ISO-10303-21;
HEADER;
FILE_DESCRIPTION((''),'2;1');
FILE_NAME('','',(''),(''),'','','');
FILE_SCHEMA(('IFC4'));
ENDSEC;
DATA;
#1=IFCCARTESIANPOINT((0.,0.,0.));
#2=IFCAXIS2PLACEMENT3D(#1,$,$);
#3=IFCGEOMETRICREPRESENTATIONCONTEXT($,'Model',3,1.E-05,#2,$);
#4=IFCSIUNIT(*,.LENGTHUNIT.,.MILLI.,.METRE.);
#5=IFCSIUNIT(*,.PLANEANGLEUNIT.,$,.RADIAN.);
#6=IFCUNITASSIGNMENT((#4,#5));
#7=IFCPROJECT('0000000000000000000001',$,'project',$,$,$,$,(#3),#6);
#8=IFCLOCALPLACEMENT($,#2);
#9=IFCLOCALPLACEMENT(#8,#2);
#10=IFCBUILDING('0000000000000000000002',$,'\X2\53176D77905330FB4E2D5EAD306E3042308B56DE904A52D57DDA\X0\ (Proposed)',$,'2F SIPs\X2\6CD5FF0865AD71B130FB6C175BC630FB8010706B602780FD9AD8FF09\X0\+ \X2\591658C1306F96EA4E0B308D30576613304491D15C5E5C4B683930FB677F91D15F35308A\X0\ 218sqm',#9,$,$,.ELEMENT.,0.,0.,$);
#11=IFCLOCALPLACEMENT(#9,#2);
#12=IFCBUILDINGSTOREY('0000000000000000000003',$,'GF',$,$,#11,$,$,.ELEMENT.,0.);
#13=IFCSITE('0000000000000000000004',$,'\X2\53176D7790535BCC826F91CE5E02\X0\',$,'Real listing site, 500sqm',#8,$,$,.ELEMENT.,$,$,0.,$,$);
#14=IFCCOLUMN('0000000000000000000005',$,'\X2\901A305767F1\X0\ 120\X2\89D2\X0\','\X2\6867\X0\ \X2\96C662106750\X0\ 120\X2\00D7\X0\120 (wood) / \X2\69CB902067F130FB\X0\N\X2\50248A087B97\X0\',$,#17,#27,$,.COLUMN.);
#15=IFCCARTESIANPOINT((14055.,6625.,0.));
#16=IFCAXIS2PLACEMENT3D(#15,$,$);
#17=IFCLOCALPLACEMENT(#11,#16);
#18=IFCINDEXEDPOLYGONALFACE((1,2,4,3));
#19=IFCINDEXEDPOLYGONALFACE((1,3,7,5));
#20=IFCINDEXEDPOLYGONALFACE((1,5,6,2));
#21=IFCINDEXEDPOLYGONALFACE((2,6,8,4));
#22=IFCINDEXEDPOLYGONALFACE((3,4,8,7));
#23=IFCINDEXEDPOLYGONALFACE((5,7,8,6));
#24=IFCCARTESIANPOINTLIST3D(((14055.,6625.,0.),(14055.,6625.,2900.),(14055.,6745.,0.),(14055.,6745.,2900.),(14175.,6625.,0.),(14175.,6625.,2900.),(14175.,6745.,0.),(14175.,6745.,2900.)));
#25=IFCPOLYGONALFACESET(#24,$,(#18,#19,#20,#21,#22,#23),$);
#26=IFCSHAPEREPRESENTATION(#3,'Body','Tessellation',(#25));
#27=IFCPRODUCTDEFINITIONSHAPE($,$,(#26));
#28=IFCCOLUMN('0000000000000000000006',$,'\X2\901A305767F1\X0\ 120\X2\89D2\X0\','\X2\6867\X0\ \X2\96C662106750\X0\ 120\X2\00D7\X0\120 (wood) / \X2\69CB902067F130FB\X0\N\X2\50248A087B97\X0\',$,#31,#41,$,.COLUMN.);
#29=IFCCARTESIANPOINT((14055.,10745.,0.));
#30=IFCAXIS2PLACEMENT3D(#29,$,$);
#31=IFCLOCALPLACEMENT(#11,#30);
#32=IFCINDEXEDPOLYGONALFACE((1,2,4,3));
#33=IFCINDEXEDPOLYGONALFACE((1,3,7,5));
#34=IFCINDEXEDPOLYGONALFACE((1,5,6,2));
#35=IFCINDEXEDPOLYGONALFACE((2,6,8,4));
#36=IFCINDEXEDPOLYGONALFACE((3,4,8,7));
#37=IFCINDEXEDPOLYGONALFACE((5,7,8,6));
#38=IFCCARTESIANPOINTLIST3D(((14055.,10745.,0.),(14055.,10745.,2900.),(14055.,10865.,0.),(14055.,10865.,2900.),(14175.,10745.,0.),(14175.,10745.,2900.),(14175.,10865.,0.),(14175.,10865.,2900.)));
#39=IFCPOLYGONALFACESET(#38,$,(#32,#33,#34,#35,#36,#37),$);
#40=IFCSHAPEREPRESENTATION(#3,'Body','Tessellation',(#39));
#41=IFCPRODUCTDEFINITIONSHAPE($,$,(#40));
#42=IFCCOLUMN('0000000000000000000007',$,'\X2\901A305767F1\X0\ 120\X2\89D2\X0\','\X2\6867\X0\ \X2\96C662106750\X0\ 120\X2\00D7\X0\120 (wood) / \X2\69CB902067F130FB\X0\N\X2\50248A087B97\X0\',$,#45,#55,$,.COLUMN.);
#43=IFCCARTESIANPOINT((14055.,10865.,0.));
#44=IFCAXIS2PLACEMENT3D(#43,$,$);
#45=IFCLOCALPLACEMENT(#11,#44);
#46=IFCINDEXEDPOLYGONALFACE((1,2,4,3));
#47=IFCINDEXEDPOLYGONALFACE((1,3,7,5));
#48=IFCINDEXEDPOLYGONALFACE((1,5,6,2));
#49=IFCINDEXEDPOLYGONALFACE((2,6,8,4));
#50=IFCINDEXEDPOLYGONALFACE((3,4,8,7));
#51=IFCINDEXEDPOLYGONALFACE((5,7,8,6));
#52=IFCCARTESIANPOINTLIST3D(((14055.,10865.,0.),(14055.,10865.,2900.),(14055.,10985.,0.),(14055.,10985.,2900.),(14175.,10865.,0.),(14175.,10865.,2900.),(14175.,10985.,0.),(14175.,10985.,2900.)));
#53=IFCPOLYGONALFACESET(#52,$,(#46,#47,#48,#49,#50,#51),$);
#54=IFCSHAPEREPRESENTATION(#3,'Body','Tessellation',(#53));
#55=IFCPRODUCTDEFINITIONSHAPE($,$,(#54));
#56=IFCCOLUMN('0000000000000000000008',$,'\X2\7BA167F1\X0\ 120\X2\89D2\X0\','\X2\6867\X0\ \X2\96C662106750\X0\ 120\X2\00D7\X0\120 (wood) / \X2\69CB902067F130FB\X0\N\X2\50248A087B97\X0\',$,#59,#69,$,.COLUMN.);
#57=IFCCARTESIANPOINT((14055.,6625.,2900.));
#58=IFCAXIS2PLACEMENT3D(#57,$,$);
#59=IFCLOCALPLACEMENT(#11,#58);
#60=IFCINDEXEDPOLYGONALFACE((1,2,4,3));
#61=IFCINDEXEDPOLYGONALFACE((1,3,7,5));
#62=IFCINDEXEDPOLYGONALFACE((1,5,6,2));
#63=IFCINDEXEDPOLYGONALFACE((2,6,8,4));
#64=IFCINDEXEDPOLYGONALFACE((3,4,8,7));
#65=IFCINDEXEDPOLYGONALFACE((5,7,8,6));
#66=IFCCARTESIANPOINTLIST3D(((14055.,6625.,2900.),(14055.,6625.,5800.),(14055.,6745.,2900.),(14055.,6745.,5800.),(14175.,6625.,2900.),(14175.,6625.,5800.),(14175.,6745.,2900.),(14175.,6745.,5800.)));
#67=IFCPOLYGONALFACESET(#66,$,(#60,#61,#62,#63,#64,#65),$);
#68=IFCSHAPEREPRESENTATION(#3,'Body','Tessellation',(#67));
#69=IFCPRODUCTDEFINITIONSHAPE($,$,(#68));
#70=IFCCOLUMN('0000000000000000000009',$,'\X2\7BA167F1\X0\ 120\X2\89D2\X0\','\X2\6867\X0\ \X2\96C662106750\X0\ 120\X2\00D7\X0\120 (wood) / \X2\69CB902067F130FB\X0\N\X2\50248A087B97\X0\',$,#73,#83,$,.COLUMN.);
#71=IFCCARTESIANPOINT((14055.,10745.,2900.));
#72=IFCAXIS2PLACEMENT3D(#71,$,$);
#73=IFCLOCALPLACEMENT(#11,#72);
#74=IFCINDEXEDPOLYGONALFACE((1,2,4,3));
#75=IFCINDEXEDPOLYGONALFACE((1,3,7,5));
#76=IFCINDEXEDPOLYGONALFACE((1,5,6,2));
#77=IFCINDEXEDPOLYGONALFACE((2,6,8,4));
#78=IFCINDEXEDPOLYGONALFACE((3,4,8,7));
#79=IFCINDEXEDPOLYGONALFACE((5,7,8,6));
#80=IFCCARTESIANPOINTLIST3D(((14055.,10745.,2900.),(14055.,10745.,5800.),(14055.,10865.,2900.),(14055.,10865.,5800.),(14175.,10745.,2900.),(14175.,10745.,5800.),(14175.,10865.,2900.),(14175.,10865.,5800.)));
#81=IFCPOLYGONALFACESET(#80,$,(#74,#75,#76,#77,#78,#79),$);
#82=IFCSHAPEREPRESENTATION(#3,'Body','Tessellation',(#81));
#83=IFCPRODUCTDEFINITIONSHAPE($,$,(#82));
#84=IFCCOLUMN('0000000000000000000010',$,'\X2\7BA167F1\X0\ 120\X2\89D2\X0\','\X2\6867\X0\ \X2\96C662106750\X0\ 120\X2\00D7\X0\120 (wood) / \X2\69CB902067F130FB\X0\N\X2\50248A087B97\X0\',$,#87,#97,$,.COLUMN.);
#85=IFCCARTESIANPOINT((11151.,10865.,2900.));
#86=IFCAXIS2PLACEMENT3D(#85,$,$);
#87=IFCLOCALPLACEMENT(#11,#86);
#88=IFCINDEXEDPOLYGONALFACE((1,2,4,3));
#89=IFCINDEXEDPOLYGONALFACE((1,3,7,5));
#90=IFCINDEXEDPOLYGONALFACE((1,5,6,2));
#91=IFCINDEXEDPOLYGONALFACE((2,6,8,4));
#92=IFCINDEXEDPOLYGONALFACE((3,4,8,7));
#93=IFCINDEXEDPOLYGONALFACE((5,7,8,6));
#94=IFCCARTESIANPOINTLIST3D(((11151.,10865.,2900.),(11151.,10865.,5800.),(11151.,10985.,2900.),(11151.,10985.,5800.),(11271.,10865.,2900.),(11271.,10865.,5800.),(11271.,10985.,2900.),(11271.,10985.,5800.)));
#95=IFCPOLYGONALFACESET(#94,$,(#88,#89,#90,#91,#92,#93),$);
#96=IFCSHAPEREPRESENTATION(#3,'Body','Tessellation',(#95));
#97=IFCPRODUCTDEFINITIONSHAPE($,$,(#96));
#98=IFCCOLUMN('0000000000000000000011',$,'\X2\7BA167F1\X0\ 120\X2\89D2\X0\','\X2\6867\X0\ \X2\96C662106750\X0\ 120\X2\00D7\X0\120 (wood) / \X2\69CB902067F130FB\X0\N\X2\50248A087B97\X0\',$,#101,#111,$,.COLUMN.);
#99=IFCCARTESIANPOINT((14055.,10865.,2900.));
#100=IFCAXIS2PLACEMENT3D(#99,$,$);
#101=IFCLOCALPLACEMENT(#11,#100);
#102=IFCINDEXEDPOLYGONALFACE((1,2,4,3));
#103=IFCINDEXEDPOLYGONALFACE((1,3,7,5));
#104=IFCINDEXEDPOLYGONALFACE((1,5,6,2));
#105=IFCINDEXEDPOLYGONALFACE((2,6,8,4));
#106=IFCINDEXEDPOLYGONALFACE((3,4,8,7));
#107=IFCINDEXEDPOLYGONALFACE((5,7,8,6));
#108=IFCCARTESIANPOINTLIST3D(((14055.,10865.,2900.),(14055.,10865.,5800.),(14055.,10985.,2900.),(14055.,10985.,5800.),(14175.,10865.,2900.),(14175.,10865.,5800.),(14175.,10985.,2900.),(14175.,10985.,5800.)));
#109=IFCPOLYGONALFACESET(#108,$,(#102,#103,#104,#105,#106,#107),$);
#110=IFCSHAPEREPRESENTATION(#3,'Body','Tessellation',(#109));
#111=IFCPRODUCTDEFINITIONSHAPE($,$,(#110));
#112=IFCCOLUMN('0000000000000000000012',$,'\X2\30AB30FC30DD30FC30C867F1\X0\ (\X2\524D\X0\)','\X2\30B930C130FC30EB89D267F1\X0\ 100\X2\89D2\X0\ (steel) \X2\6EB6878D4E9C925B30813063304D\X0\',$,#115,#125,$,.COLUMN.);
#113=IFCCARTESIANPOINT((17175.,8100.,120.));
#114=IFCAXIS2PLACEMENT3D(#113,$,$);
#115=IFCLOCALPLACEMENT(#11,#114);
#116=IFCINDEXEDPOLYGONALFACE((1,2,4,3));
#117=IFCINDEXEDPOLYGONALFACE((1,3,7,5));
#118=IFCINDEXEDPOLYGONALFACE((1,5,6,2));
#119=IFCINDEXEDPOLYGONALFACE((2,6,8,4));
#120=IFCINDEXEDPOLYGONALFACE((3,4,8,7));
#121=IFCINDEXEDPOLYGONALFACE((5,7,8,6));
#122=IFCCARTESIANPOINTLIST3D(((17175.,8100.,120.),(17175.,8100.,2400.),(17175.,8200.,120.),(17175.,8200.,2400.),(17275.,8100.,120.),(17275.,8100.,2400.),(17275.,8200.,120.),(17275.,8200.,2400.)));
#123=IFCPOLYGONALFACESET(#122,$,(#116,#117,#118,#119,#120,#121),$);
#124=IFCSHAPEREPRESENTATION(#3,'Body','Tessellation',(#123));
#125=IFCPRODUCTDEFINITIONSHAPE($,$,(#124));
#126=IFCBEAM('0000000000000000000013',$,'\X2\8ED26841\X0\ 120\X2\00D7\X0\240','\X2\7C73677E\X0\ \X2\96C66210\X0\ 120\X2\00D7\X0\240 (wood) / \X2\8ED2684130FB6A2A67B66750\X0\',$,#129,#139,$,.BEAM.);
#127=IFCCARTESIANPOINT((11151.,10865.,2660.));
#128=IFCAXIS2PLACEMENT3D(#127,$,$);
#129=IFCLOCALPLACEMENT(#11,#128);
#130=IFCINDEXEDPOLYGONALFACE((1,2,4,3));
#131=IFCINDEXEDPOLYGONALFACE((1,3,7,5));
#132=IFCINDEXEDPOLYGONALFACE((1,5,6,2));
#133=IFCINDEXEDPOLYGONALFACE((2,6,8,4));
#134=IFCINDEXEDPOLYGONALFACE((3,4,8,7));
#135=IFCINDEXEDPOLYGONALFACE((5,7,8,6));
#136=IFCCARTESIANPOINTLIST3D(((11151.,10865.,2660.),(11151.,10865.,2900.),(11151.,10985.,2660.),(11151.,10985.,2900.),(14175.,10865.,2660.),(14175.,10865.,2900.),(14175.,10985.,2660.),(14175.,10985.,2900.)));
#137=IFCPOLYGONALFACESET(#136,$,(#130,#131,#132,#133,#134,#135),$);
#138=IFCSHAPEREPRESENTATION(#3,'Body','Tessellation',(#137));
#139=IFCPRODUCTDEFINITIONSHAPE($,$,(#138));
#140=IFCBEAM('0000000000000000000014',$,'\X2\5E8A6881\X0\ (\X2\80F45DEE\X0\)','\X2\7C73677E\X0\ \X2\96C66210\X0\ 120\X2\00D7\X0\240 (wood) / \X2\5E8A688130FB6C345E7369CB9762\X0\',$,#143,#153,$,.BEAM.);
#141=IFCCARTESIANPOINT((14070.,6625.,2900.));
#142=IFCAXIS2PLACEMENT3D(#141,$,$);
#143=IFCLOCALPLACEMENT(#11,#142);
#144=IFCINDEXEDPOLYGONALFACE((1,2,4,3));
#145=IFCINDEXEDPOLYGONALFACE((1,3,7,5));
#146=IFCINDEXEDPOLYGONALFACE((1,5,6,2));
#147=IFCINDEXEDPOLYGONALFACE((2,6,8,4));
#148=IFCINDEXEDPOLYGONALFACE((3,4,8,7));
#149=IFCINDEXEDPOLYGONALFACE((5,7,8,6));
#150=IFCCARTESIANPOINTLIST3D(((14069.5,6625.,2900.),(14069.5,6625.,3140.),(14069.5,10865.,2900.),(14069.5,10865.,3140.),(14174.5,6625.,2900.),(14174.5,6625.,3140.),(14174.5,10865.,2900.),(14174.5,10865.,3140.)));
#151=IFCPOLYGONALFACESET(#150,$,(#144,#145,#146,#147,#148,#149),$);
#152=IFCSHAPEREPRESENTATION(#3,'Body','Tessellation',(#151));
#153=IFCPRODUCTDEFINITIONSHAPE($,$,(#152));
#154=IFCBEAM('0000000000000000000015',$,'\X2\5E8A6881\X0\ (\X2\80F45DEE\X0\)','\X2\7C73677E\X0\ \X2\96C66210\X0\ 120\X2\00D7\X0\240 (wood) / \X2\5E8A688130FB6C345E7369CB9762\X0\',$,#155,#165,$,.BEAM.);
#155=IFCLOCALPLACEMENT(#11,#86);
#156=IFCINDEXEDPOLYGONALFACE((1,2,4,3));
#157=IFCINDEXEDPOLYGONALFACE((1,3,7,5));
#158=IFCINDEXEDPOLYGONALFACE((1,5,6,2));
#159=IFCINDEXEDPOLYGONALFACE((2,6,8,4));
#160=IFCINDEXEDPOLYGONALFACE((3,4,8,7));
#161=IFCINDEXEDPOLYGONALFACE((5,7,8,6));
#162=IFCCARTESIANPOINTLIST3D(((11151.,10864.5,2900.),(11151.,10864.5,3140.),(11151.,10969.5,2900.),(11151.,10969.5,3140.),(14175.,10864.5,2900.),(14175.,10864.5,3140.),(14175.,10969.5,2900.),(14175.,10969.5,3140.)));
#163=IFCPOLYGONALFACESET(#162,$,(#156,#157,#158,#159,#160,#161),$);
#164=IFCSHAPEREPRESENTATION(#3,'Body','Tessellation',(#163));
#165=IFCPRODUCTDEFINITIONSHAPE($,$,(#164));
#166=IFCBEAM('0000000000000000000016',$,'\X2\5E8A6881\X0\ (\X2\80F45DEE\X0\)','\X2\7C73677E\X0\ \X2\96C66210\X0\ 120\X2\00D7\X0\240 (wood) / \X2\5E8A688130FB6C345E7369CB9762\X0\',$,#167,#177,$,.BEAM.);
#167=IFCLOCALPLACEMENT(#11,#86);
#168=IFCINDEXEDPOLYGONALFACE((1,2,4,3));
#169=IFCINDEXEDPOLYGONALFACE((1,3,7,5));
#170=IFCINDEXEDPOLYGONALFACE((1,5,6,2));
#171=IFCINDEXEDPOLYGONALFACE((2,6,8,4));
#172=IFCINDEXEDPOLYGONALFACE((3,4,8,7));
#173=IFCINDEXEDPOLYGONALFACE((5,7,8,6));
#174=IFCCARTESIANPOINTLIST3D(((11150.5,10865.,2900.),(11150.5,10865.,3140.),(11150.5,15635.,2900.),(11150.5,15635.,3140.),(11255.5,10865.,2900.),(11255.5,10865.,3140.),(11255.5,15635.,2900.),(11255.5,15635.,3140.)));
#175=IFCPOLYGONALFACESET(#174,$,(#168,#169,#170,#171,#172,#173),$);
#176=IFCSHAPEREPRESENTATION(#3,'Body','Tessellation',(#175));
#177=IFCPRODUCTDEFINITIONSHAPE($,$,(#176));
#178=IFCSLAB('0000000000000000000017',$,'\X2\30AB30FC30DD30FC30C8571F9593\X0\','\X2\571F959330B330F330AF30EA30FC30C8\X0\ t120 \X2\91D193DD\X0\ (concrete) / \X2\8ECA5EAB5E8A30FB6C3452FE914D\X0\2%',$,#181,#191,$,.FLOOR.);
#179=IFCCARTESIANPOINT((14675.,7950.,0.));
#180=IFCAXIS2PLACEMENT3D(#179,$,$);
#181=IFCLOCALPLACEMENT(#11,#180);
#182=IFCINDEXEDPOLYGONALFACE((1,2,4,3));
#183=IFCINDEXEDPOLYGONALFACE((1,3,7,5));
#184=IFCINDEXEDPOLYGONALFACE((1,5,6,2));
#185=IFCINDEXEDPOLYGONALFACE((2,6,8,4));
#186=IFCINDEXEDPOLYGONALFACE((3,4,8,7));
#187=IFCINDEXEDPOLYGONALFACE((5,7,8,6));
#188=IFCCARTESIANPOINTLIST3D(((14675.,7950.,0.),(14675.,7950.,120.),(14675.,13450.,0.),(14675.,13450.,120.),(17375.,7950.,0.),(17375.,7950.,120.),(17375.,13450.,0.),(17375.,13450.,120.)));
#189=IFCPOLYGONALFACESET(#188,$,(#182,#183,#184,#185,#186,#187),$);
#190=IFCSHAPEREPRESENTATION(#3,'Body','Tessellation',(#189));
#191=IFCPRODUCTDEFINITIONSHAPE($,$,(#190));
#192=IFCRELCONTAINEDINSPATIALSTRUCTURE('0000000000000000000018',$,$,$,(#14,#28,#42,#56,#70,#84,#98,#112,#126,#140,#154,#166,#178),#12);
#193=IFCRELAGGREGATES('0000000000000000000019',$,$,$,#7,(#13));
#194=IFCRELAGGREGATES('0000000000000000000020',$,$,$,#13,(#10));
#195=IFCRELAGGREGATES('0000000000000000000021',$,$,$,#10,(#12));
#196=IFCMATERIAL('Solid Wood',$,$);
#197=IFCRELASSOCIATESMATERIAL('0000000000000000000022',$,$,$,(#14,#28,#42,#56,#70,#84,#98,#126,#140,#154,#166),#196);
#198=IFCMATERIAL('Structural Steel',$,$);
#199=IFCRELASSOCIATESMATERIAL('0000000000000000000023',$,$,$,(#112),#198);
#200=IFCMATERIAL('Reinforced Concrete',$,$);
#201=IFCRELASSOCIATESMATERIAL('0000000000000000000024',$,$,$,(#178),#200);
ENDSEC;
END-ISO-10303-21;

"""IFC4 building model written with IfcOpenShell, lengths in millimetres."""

from ifc_helpers import new_model, si_unit, frame, frame_2d, origin, place, context, project, spatial, rectangle, extrude, material, element, save


model = new_model("IFC4")

# Units and contexts
model_context = context("Model", 3, precision=1e-05, world=origin())
ifc_project = project(units=[si_unit("LENGTHUNIT", "METRE", prefix="MILLI"), si_unit("PLANEANGLEUNIT", "RADIAN")], contexts=[model_context])

# Site, building, storey
site_placement = place(None, origin())
site = spatial("IfcSite", under=ifc_project, at=site_placement, Name="北海道富良野市", ObjectType="Real listing site, 500sqm", CompositionType="ELEMENT", RefElevation=0.0)
building_placement = place(site_placement, origin())
building = spatial("IfcBuilding", under=site, at=building_placement, Name="北海道・中庭のある回遊動線 (Proposed)", ObjectType="2F SIPs法（断熱・気密・耐火性能高）+ 外壁は雪下ろし易い金属屋根・板金張り 218sqm", CompositionType="ELEMENT", ElevationOfRefHeight=0.0, ElevationOfTerrain=0.0)
storey_placement = place(building_placement, origin())
storey = spatial("IfcBuildingStorey", under=building, at=storey_placement, Name="GF", CompositionType="ELEMENT", Elevation=0.0)

# Columns
ifc_material_1 = material(Name="Solid Wood")
column_1_placement = place(storey_placement, frame((14055.0, 6625.0, 0.0)))
element("IfcColumn", 1, at=column_1_placement, inside=storey, material=ifc_material_1, Name="通し柱 120角", Description="桧 集成材 120×120 (wood) / 構造柱・N値計算", PredefinedType="COLUMN", context=model_context, shape_type="SweptSolid", body=[
    extrude(rectangle(XDim=120.0, YDim=120.0, at=frame_2d((60.0, 60.0))), frame((14055.0, 6625.0, 0.0)), (0.0, 0.0, 1.0), 2900.0),
])
column_2_placement = place(storey_placement, frame((14055.0, 10745.0, 0.0)))
element("IfcColumn", 2, at=column_2_placement, inside=storey, material=ifc_material_1, Name="通し柱 120角", Description="桧 集成材 120×120 (wood) / 構造柱・N値計算", PredefinedType="COLUMN", context=model_context, shape_type="SweptSolid", body=[
    extrude(rectangle(XDim=120.0, YDim=120.0, at=frame_2d((60.0, 60.0))), frame((14055.0, 10745.0, 0.0)), (0.0, 0.0, 1.0), 2900.0),
])
column_3_placement = place(storey_placement, frame((14055.0, 10865.0, 0.0)))
element("IfcColumn", 3, at=column_3_placement, inside=storey, material=ifc_material_1, Name="通し柱 120角", Description="桧 集成材 120×120 (wood) / 構造柱・N値計算", PredefinedType="COLUMN", context=model_context, shape_type="SweptSolid", body=[
    extrude(rectangle(XDim=120.0, YDim=120.0, at=frame_2d((60.0, 60.0))), frame((14055.0, 10865.0, 0.0)), (0.0, 0.0, 1.0), 2900.0),
])
column_4_placement = place(storey_placement, frame((14055.0, 6625.0, 2900.0)))
element("IfcColumn", 4, at=column_4_placement, inside=storey, material=ifc_material_1, Name="管柱 120角", Description="桧 集成材 120×120 (wood) / 構造柱・N値計算", PredefinedType="COLUMN", context=model_context, shape_type="SweptSolid", body=[
    extrude(rectangle(XDim=120.0, YDim=120.0, at=frame_2d((60.0, 60.0))), frame((14055.0, 6625.0, 2900.0)), (0.0, 0.0, 1.0), 2900.0),
])
column_5_placement = place(storey_placement, frame((14055.0, 10745.0, 2900.0)))
element("IfcColumn", 5, at=column_5_placement, inside=storey, material=ifc_material_1, Name="管柱 120角", Description="桧 集成材 120×120 (wood) / 構造柱・N値計算", PredefinedType="COLUMN", context=model_context, shape_type="SweptSolid", body=[
    extrude(rectangle(XDim=120.0, YDim=120.0, at=frame_2d((60.0, 60.0))), frame((14055.0, 10745.0, 2900.0)), (0.0, 0.0, 1.0), 2900.0),
])
column_6_placement = place(storey_placement, frame((11151.0, 10865.0, 2900.0)))
element("IfcColumn", 6, at=column_6_placement, inside=storey, material=ifc_material_1, Name="管柱 120角", Description="桧 集成材 120×120 (wood) / 構造柱・N値計算", PredefinedType="COLUMN", context=model_context, shape_type="SweptSolid", body=[
    extrude(rectangle(XDim=120.0, YDim=120.0, at=frame_2d((60.0, 60.0))), frame((11151.0, 10865.0, 2900.0)), (0.0, 0.0, 1.0), 2900.0),
])
column_7_placement = place(storey_placement, frame((14055.0, 10865.0, 2900.0)))
element("IfcColumn", 7, at=column_7_placement, inside=storey, material=ifc_material_1, Name="管柱 120角", Description="桧 集成材 120×120 (wood) / 構造柱・N値計算", PredefinedType="COLUMN", context=model_context, shape_type="SweptSolid", body=[
    extrude(rectangle(XDim=120.0, YDim=120.0, at=frame_2d((60.0, 60.0))), frame((14055.0, 10865.0, 2900.0)), (0.0, 0.0, 1.0), 2900.0),
])
ifc_material_2 = material(Name="Structural Steel")
column_8_placement = place(storey_placement, frame((17175.0, 8100.0, 120.0)))
element("IfcColumn", 8, at=column_8_placement, inside=storey, material=ifc_material_2, Name="カーポート柱 (前)", Description="スチール角柱 100角 (steel) 溶融亜鉛めっき", PredefinedType="COLUMN", context=model_context, shape_type="SweptSolid", body=[
    extrude(rectangle(XDim=100.0, YDim=100.0, at=frame_2d((50.0, 50.0))), frame((17175.0, 8100.0, 120.0)), (0.0, 0.0, 1.0), 2280.0),
])

# Beams
beam_1_placement = place(storey_placement, frame((11151.0, 10865.0, 2660.0)))
element("IfcBeam", 9, at=beam_1_placement, inside=storey, material=ifc_material_1, Name="軒桁 120×240", Description="米松 集成 120×240 (wood) / 軒桁・横架材", PredefinedType="BEAM", context=model_context, shape_type="SweptSolid", body=[
    extrude(rectangle(XDim=3024.0, YDim=120.0, at=frame_2d((1512.0, 60.0))), frame((11151.0, 10865.0, 2660.0)), (0.0, 0.0, 1.0), 240.0),
])
beam_2_placement = place(storey_placement, frame((14070.0, 6625.0, 2900.0)))
element("IfcBeam", 10, at=beam_2_placement, inside=storey, material=ifc_material_1, Name="床梁 (胴差)", Description="米松 集成 120×240 (wood) / 床梁・水平構面", PredefinedType="BEAM", context=model_context, shape_type="SweptSolid", body=[
    extrude(rectangle(XDim=105.0, YDim=4240.0, at=frame_2d((52.0, 2120.0))), frame((14070.0, 6625.0, 2900.0)), (0.0, 0.0, 1.0), 240.0),
])
beam_3_placement = place(storey_placement, frame((11151.0, 10865.0, 2900.0)))
element("IfcBeam", 11, at=beam_3_placement, inside=storey, material=ifc_material_1, Name="床梁 (胴差)", Description="米松 集成 120×240 (wood) / 床梁・水平構面", PredefinedType="BEAM", context=model_context, shape_type="SweptSolid", body=[
    extrude(rectangle(XDim=3024.0, YDim=105.0, at=frame_2d((1512.0, 52.0))), frame((11151.0, 10865.0, 2900.0)), (0.0, 0.0, 1.0), 240.0),
])
beam_4_placement = place(storey_placement, frame((11151.0, 10865.0, 2900.0)))
element("IfcBeam", 12, at=beam_4_placement, inside=storey, material=ifc_material_1, Name="床梁 (胴差)", Description="米松 集成 120×240 (wood) / 床梁・水平構面", PredefinedType="BEAM", context=model_context, shape_type="SweptSolid", body=[
    extrude(rectangle(XDim=105.0, YDim=4770.0, at=frame_2d((52.0, 2385.0))), frame((11151.0, 10865.0, 2900.0)), (0.0, 0.0, 1.0), 240.0),
])

# Slab
ifc_material_3 = material(Name="Reinforced Concrete")
slab_placement = place(storey_placement, frame((14675.0, 7950.0, 0.0)))
element("IfcSlab", 13, at=slab_placement, inside=storey, material=ifc_material_3, Name="カーポート土間", Description="土間コンクリート t120 金鏝 (concrete) / 車庫床・水勾配2%", PredefinedType="FLOOR", context=model_context, shape_type="SweptSolid", body=[
    extrude(rectangle(XDim=2700.0, YDim=5500.0, at=frame_2d((1350.0, 2750.0))), frame((14675.0, 7950.0, 0.0)), (0.0, 0.0, 1.0), 120.0),
])

save(model, "model.ifc")
